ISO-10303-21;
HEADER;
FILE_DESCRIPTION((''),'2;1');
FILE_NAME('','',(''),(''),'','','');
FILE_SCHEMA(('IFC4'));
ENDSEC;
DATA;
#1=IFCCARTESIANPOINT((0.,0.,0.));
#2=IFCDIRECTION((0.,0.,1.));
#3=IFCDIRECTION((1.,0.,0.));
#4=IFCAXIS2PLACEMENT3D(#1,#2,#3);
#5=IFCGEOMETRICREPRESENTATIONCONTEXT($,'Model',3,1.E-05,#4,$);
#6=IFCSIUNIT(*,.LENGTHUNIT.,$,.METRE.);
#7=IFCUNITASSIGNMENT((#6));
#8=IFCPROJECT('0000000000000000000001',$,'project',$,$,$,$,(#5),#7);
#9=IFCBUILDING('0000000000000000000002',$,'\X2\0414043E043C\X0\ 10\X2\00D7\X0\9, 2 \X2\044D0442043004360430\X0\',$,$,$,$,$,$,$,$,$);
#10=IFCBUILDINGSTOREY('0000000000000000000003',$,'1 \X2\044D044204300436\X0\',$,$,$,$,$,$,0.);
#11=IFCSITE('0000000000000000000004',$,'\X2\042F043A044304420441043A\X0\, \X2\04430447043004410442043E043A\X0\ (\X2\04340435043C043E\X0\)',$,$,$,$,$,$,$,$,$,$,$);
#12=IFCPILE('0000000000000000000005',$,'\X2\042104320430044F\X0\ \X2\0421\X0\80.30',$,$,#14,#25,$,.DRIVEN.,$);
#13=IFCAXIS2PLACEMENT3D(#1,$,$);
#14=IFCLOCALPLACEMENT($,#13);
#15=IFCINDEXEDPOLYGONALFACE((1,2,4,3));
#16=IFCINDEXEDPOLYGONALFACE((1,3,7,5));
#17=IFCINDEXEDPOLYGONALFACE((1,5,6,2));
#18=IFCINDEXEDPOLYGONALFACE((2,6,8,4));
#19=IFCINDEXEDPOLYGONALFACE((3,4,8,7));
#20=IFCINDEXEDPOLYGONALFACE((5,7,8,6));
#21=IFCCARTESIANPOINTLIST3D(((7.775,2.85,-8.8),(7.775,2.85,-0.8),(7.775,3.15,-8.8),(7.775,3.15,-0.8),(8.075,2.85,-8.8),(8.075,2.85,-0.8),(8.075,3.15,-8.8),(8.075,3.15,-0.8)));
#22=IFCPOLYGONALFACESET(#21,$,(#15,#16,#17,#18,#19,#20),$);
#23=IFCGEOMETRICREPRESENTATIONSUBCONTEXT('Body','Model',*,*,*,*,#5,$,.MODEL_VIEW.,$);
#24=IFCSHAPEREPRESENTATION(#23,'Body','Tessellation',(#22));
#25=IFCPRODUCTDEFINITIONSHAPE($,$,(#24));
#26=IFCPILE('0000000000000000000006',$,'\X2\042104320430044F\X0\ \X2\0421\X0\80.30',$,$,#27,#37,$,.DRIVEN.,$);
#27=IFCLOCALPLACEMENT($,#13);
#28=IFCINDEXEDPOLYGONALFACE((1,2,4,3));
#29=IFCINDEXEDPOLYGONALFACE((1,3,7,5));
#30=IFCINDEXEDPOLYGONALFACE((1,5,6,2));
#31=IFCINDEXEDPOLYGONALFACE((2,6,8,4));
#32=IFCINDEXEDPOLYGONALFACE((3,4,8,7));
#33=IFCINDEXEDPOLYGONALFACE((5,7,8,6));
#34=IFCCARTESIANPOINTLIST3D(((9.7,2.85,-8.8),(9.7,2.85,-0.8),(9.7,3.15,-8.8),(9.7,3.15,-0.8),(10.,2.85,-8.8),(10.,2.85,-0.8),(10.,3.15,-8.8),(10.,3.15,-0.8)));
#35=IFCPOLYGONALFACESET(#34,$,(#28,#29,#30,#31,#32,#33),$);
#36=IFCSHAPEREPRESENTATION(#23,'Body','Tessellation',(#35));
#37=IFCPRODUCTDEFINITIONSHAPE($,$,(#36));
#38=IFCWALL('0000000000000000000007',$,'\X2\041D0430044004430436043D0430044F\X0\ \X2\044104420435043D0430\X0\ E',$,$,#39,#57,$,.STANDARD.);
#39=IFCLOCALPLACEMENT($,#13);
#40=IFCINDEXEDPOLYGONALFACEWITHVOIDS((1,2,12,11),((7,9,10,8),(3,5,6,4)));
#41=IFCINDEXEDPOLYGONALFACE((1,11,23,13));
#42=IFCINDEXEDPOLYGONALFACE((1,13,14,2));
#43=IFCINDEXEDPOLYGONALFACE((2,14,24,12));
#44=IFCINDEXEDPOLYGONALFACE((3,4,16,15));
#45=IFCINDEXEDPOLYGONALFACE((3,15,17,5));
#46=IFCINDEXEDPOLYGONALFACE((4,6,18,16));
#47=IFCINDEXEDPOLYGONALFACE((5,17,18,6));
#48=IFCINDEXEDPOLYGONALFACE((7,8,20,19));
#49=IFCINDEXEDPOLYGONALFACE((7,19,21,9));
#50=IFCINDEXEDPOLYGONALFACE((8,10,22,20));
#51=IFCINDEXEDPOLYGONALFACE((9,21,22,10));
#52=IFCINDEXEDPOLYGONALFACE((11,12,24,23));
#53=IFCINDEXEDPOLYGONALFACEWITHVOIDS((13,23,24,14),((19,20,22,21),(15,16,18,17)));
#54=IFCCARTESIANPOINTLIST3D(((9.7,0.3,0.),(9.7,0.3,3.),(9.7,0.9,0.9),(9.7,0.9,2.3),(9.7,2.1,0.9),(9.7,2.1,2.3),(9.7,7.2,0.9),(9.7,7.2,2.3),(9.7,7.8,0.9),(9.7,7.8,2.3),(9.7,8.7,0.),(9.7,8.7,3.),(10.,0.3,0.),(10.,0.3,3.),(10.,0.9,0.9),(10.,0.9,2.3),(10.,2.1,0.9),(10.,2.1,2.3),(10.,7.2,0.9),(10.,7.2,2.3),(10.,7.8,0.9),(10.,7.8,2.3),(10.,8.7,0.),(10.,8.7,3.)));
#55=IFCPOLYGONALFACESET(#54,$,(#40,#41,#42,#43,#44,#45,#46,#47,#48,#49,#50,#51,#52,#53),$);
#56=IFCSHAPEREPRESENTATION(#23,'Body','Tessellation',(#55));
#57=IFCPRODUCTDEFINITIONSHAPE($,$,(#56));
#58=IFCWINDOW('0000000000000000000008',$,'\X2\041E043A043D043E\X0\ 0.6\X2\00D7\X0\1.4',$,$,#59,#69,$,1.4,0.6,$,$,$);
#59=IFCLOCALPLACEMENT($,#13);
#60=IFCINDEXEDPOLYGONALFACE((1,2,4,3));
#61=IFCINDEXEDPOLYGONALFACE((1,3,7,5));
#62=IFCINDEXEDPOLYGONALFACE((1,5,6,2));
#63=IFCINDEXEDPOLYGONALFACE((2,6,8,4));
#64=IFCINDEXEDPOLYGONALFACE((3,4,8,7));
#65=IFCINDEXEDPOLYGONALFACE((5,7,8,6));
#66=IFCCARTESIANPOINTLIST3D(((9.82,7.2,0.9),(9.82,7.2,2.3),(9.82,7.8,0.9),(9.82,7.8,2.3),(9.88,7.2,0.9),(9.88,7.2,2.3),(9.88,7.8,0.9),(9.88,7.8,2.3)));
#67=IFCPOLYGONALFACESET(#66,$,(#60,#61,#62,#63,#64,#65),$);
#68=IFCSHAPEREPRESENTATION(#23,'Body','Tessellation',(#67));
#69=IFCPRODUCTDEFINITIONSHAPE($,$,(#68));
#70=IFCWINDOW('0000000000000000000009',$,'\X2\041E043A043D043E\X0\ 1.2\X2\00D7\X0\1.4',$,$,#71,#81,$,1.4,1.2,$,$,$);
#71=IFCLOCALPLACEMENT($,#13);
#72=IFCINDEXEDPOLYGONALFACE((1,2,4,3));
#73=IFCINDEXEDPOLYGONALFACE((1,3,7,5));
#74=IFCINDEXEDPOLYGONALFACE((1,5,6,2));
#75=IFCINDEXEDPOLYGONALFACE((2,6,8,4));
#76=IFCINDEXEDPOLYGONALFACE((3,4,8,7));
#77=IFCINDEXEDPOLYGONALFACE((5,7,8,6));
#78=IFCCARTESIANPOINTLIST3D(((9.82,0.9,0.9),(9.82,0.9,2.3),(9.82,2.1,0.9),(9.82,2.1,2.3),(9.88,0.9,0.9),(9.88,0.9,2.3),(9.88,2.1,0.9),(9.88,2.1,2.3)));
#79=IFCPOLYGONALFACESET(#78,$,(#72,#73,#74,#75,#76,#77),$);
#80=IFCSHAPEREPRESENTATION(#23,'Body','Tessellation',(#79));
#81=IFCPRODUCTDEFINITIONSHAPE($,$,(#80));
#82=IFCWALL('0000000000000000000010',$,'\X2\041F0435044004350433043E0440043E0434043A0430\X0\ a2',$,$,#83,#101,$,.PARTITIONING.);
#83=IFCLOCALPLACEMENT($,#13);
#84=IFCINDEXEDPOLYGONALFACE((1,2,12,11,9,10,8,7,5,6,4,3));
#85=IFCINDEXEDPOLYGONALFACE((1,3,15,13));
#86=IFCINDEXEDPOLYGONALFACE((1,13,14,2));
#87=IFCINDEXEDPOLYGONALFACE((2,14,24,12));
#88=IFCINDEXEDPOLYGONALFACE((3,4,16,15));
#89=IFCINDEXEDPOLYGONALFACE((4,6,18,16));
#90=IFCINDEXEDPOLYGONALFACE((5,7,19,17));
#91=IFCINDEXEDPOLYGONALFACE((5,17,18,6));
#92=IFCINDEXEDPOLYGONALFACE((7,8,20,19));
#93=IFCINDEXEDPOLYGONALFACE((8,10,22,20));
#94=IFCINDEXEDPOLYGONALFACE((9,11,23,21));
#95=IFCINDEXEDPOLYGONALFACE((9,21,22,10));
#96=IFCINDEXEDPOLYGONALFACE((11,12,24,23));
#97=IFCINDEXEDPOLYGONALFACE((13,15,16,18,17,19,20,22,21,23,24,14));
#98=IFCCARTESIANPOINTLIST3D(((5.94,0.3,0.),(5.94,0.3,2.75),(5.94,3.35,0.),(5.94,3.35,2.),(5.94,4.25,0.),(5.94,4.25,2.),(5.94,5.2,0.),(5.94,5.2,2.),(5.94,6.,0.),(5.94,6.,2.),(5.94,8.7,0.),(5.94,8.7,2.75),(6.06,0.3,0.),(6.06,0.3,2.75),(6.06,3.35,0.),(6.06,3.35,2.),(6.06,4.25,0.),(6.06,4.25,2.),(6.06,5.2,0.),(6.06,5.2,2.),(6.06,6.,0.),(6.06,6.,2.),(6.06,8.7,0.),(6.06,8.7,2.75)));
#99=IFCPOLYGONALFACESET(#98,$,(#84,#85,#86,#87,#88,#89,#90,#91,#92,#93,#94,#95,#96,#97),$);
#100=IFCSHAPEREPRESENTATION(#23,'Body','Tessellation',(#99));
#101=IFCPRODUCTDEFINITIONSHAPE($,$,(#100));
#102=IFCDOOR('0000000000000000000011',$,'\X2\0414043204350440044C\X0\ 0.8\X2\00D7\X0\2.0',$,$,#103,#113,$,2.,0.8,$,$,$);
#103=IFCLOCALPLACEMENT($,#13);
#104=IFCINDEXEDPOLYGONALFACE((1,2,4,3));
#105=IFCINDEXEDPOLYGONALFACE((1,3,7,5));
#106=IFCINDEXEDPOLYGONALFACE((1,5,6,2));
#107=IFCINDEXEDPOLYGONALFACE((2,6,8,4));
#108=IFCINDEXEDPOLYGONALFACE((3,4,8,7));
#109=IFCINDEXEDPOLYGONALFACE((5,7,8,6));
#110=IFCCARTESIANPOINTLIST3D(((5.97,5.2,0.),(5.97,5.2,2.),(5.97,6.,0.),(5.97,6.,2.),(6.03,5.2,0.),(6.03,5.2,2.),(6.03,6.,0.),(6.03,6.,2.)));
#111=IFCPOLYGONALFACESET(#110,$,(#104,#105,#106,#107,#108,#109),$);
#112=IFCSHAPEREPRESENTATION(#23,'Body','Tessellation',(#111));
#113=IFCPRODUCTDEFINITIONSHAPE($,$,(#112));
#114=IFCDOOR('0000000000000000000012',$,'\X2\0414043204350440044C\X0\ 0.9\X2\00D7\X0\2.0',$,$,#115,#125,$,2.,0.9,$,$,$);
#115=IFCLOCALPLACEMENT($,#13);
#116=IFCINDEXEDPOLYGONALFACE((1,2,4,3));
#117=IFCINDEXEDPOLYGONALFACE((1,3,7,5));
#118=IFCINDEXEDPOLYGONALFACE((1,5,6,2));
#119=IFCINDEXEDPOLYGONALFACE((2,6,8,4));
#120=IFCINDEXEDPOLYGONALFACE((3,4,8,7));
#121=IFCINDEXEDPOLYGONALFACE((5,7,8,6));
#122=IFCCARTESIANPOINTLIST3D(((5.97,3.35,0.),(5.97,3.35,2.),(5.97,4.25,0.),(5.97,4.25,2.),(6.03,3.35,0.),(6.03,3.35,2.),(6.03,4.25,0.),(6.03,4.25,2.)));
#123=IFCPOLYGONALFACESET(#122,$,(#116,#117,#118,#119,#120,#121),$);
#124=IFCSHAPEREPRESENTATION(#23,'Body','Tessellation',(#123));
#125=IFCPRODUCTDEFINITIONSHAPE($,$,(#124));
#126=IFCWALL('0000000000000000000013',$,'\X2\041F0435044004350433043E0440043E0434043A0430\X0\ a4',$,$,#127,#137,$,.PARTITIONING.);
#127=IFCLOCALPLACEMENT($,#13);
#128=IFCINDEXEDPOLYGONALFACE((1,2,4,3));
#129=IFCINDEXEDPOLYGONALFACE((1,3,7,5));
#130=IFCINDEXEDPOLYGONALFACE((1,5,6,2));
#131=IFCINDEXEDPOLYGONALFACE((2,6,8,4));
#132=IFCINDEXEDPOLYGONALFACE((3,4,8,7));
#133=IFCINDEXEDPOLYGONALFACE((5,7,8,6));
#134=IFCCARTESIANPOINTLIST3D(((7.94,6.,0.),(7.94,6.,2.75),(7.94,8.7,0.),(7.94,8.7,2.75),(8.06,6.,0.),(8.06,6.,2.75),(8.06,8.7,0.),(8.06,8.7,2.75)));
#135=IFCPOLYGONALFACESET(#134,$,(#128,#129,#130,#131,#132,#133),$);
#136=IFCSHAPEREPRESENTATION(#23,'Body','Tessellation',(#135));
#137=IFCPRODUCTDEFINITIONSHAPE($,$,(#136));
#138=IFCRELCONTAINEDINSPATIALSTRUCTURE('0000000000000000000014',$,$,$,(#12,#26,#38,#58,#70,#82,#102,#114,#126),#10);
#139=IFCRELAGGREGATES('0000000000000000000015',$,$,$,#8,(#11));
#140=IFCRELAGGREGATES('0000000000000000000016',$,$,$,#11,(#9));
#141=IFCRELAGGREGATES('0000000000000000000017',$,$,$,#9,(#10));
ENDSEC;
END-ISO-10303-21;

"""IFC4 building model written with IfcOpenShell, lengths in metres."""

from ifc_helpers import new_model, si_unit, frame, origin_with_axes, place, context, subcontext, project, spatial, indexed_curve, rectangle, outline, extrude, element, fill, save


model = new_model("IFC4")

# Units and contexts
model_context = context("Model", 3, precision=1e-05, world=origin_with_axes())
body_context = subcontext(model_context, "Body", "Model", "MODEL_VIEW")
ifc_project = project(units=[si_unit("LENGTHUNIT", "METRE")], contexts=[model_context])

# Site, building, storey
site = spatial("IfcSite", under=ifc_project, Name="Якутск, участок (демо)")
building = spatial("IfcBuilding", under=site, Name="Дом 10×9, 2 этажа")
storey = spatial("IfcBuildingStorey", under=building, Name="1 этаж", Elevation=0.0)

# Piles
for number, where, z_axis, x_axis, name in (
    (1, (7.925, 3.0, -8.8), (0.0, 0.0, 1.0), (1.0, 0.0, 0.0), "Свая С80.30"),
    (2, (9.85, 3.0, -8.8), (0.0, 0.0, 1.0), (1.0, 0.0, 0.0), "Свая С80.30"),
):
    element("IfcPile", number, at=place(None, frame(where, z_axis=z_axis, x_axis=x_axis)), inside=storey, Name=name, PredefinedType="DRIVEN", context=body_context, shape_type="SweptSolid", body=[
        extrude(rectangle(XDim=0.3, YDim=0.3), origin_with_axes(), (0.0, 0.0, 1.0), 8.0),
    ])

# Wall, openings, windows
wall_1_placement = place(None, frame((10.0, 0.3, 0.0), z_axis=(0.0, 0.0, 1.0), x_axis=(0.0, 1.0, 0.0)))
wall_1 = element("IfcWall", 3, at=wall_1_placement, inside=storey, Name="Наружная стена E", PredefinedType="STANDARD", context=body_context, shape_type="SweptSolid", body=[
    extrude(outline(indexed_curve([(0.0, 0.0), (0.0, 0.3), (8.4, 0.3), (8.4, 0.0), (0.0, 0.0)], self_intersect=False)), origin_with_axes(), (0.0, 0.0, 1.0), 3.0),
])
opening_1_placement = place(wall_1_placement, frame((6.9, -0.05, 0.9), z_axis=(0.0, 0.0, 1.0), x_axis=(1.0, 0.0, 0.0)))
opening_1 = element("IfcOpeningElement", 4, at=opening_1_placement, cuts=wall_1, context=body_context, shape_type="SweptSolid", body=[
    extrude(outline(indexed_curve([(0.0, 0.0), (0.0, 0.4), (0.6, 0.4), (0.6, 0.0), (0.0, 0.0)], self_intersect=False)), origin_with_axes(), (0.0, 0.0, 1.0), 1.4),
])
opening_2_placement = place(wall_1_placement, frame((0.6, -0.05, 0.9), z_axis=(0.0, 0.0, 1.0), x_axis=(1.0, 0.0, 0.0)))
opening_2 = element("IfcOpeningElement", 5, at=opening_2_placement, cuts=wall_1, context=body_context, shape_type="SweptSolid", body=[
    extrude(outline(indexed_curve([(0.0, 0.0), (0.0, 0.4), (1.2, 0.4), (1.2, 0.0), (0.0, 0.0)], self_intersect=False)), origin_with_axes(), (0.0, 0.0, 1.0), 1.4),
])
window_1_placement = place(opening_1_placement, frame((0.0, 0.17, 0.0), z_axis=(0.0, 0.0, 1.0), x_axis=(1.0, 0.0, 0.0)))
window_1 = element("IfcWindow", 6, at=window_1_placement, inside=storey, Name="Окно 0.6×1.4", OverallHeight=1.4, OverallWidth=0.6, context=body_context, shape_type="SweptSolid", body=[
    extrude(outline(indexed_curve([(0.0, 0.0), (0.0, 0.06), (0.6, 0.06), (0.6, 0.0), (0.0, 0.0)], self_intersect=False)), origin_with_axes(), (0.0, 0.0, 1.0), 1.4),
])
fill(opening_1, window_1)
window_2_placement = place(opening_2_placement, frame((0.0, 0.17, 0.0), z_axis=(0.0, 0.0, 1.0), x_axis=(1.0, 0.0, 0.0)))
window_2 = element("IfcWindow", 7, at=window_2_placement, inside=storey, Name="Окно 1.2×1.4", OverallHeight=1.4, OverallWidth=1.2, context=body_context, shape_type="SweptSolid", body=[
    extrude(outline(indexed_curve([(0.0, 0.0), (0.0, 0.06), (1.2, 0.06), (1.2, 0.0), (0.0, 0.0)], self_intersect=False)), origin_with_axes(), (0.0, 0.0, 1.0), 1.4),
])
fill(opening_2, window_2)

# Wall, openings, doors
wall_2_placement = place(None, frame((6.06, 0.3, 0.0), z_axis=(0.0, 0.0, 1.0), x_axis=(0.0, 1.0, 0.0)))
wall_2 = element("IfcWall", 8, at=wall_2_placement, inside=storey, Name="Перегородка a2", PredefinedType="PARTITIONING", context=body_context, shape_type="SweptSolid", body=[
    extrude(outline(indexed_curve([(0.0, 0.0), (0.0, 0.12), (8.4, 0.12), (8.4, 0.0), (0.0, 0.0)], self_intersect=False)), origin_with_axes(), (0.0, 0.0, 1.0), 2.75),
])
opening_3_placement = place(wall_2_placement, frame((4.9, -0.05, 0.0), z_axis=(0.0, 0.0, 1.0), x_axis=(1.0, 0.0, 0.0)))
opening_3 = element("IfcOpeningElement", 9, at=opening_3_placement, cuts=wall_2, context=body_context, shape_type="SweptSolid", body=[
    extrude(outline(indexed_curve([(0.0, 0.0), (0.0, 0.22), (0.8, 0.22), (0.8, 0.0), (0.0, 0.0)], self_intersect=False)), origin_with_axes(), (0.0, 0.0, 1.0), 2.0),
])
opening_4_placement = place(wall_2_placement, frame((3.05, -0.05, 0.0), z_axis=(0.0, 0.0, 1.0), x_axis=(1.0, 0.0, 0.0)))
opening_4 = element("IfcOpeningElement", 10, at=opening_4_placement, cuts=wall_2, context=body_context, shape_type="SweptSolid", body=[
    extrude(outline(indexed_curve([(0.0, 0.0), (0.0, 0.22), (0.9, 0.22), (0.9, 0.0), (0.0, 0.0)], self_intersect=False)), origin_with_axes(), (0.0, 0.0, 1.0), 2.0),
])
door_1_placement = place(opening_3_placement, frame((0.0, 0.08, 0.0), z_axis=(0.0, 0.0, 1.0), x_axis=(1.0, 0.0, 0.0)))
door_1 = element("IfcDoor", 11, at=door_1_placement, inside=storey, Name="Дверь 0.8×2.0", OverallHeight=2.0, OverallWidth=0.8, context=body_context, shape_type="SweptSolid", body=[
    extrude(outline(indexed_curve([(0.0, 0.0), (0.0, 0.06), (0.8, 0.06), (0.8, 0.0), (0.0, 0.0)], self_intersect=False)), origin_with_axes(), (0.0, 0.0, 1.0), 2.0),
])
fill(opening_3, door_1)
door_2_placement = place(opening_4_placement, frame((0.0, 0.08, 0.0), z_axis=(0.0, 0.0, 1.0), x_axis=(1.0, 0.0, 0.0)))
door_2 = element("IfcDoor", 12, at=door_2_placement, inside=storey, Name="Дверь 0.9×2.0", OverallHeight=2.0, OverallWidth=0.9, context=body_context, shape_type="SweptSolid", body=[
    extrude(outline(indexed_curve([(0.0, 0.0), (0.0, 0.06), (0.9, 0.06), (0.9, 0.0), (0.0, 0.0)], self_intersect=False)), origin_with_axes(), (0.0, 0.0, 1.0), 2.0),
])
fill(opening_4, door_2)

# Wall
wall_3_placement = place(None, frame((8.06, 6.0, 0.0), z_axis=(0.0, 0.0, 1.0), x_axis=(0.0, 1.0, 0.0)))
element("IfcWall", 13, at=wall_3_placement, inside=storey, Name="Перегородка a4", PredefinedType="PARTITIONING", context=body_context, shape_type="SweptSolid", body=[
    extrude(outline(indexed_curve([(0.0, 0.0), (0.0, 0.12), (2.7, 0.12), (2.7, 0.0), (0.0, 0.0)], self_intersect=False)), origin_with_axes(), (0.0, 0.0, 1.0), 2.75),
])

save(model, "model.ifc")
